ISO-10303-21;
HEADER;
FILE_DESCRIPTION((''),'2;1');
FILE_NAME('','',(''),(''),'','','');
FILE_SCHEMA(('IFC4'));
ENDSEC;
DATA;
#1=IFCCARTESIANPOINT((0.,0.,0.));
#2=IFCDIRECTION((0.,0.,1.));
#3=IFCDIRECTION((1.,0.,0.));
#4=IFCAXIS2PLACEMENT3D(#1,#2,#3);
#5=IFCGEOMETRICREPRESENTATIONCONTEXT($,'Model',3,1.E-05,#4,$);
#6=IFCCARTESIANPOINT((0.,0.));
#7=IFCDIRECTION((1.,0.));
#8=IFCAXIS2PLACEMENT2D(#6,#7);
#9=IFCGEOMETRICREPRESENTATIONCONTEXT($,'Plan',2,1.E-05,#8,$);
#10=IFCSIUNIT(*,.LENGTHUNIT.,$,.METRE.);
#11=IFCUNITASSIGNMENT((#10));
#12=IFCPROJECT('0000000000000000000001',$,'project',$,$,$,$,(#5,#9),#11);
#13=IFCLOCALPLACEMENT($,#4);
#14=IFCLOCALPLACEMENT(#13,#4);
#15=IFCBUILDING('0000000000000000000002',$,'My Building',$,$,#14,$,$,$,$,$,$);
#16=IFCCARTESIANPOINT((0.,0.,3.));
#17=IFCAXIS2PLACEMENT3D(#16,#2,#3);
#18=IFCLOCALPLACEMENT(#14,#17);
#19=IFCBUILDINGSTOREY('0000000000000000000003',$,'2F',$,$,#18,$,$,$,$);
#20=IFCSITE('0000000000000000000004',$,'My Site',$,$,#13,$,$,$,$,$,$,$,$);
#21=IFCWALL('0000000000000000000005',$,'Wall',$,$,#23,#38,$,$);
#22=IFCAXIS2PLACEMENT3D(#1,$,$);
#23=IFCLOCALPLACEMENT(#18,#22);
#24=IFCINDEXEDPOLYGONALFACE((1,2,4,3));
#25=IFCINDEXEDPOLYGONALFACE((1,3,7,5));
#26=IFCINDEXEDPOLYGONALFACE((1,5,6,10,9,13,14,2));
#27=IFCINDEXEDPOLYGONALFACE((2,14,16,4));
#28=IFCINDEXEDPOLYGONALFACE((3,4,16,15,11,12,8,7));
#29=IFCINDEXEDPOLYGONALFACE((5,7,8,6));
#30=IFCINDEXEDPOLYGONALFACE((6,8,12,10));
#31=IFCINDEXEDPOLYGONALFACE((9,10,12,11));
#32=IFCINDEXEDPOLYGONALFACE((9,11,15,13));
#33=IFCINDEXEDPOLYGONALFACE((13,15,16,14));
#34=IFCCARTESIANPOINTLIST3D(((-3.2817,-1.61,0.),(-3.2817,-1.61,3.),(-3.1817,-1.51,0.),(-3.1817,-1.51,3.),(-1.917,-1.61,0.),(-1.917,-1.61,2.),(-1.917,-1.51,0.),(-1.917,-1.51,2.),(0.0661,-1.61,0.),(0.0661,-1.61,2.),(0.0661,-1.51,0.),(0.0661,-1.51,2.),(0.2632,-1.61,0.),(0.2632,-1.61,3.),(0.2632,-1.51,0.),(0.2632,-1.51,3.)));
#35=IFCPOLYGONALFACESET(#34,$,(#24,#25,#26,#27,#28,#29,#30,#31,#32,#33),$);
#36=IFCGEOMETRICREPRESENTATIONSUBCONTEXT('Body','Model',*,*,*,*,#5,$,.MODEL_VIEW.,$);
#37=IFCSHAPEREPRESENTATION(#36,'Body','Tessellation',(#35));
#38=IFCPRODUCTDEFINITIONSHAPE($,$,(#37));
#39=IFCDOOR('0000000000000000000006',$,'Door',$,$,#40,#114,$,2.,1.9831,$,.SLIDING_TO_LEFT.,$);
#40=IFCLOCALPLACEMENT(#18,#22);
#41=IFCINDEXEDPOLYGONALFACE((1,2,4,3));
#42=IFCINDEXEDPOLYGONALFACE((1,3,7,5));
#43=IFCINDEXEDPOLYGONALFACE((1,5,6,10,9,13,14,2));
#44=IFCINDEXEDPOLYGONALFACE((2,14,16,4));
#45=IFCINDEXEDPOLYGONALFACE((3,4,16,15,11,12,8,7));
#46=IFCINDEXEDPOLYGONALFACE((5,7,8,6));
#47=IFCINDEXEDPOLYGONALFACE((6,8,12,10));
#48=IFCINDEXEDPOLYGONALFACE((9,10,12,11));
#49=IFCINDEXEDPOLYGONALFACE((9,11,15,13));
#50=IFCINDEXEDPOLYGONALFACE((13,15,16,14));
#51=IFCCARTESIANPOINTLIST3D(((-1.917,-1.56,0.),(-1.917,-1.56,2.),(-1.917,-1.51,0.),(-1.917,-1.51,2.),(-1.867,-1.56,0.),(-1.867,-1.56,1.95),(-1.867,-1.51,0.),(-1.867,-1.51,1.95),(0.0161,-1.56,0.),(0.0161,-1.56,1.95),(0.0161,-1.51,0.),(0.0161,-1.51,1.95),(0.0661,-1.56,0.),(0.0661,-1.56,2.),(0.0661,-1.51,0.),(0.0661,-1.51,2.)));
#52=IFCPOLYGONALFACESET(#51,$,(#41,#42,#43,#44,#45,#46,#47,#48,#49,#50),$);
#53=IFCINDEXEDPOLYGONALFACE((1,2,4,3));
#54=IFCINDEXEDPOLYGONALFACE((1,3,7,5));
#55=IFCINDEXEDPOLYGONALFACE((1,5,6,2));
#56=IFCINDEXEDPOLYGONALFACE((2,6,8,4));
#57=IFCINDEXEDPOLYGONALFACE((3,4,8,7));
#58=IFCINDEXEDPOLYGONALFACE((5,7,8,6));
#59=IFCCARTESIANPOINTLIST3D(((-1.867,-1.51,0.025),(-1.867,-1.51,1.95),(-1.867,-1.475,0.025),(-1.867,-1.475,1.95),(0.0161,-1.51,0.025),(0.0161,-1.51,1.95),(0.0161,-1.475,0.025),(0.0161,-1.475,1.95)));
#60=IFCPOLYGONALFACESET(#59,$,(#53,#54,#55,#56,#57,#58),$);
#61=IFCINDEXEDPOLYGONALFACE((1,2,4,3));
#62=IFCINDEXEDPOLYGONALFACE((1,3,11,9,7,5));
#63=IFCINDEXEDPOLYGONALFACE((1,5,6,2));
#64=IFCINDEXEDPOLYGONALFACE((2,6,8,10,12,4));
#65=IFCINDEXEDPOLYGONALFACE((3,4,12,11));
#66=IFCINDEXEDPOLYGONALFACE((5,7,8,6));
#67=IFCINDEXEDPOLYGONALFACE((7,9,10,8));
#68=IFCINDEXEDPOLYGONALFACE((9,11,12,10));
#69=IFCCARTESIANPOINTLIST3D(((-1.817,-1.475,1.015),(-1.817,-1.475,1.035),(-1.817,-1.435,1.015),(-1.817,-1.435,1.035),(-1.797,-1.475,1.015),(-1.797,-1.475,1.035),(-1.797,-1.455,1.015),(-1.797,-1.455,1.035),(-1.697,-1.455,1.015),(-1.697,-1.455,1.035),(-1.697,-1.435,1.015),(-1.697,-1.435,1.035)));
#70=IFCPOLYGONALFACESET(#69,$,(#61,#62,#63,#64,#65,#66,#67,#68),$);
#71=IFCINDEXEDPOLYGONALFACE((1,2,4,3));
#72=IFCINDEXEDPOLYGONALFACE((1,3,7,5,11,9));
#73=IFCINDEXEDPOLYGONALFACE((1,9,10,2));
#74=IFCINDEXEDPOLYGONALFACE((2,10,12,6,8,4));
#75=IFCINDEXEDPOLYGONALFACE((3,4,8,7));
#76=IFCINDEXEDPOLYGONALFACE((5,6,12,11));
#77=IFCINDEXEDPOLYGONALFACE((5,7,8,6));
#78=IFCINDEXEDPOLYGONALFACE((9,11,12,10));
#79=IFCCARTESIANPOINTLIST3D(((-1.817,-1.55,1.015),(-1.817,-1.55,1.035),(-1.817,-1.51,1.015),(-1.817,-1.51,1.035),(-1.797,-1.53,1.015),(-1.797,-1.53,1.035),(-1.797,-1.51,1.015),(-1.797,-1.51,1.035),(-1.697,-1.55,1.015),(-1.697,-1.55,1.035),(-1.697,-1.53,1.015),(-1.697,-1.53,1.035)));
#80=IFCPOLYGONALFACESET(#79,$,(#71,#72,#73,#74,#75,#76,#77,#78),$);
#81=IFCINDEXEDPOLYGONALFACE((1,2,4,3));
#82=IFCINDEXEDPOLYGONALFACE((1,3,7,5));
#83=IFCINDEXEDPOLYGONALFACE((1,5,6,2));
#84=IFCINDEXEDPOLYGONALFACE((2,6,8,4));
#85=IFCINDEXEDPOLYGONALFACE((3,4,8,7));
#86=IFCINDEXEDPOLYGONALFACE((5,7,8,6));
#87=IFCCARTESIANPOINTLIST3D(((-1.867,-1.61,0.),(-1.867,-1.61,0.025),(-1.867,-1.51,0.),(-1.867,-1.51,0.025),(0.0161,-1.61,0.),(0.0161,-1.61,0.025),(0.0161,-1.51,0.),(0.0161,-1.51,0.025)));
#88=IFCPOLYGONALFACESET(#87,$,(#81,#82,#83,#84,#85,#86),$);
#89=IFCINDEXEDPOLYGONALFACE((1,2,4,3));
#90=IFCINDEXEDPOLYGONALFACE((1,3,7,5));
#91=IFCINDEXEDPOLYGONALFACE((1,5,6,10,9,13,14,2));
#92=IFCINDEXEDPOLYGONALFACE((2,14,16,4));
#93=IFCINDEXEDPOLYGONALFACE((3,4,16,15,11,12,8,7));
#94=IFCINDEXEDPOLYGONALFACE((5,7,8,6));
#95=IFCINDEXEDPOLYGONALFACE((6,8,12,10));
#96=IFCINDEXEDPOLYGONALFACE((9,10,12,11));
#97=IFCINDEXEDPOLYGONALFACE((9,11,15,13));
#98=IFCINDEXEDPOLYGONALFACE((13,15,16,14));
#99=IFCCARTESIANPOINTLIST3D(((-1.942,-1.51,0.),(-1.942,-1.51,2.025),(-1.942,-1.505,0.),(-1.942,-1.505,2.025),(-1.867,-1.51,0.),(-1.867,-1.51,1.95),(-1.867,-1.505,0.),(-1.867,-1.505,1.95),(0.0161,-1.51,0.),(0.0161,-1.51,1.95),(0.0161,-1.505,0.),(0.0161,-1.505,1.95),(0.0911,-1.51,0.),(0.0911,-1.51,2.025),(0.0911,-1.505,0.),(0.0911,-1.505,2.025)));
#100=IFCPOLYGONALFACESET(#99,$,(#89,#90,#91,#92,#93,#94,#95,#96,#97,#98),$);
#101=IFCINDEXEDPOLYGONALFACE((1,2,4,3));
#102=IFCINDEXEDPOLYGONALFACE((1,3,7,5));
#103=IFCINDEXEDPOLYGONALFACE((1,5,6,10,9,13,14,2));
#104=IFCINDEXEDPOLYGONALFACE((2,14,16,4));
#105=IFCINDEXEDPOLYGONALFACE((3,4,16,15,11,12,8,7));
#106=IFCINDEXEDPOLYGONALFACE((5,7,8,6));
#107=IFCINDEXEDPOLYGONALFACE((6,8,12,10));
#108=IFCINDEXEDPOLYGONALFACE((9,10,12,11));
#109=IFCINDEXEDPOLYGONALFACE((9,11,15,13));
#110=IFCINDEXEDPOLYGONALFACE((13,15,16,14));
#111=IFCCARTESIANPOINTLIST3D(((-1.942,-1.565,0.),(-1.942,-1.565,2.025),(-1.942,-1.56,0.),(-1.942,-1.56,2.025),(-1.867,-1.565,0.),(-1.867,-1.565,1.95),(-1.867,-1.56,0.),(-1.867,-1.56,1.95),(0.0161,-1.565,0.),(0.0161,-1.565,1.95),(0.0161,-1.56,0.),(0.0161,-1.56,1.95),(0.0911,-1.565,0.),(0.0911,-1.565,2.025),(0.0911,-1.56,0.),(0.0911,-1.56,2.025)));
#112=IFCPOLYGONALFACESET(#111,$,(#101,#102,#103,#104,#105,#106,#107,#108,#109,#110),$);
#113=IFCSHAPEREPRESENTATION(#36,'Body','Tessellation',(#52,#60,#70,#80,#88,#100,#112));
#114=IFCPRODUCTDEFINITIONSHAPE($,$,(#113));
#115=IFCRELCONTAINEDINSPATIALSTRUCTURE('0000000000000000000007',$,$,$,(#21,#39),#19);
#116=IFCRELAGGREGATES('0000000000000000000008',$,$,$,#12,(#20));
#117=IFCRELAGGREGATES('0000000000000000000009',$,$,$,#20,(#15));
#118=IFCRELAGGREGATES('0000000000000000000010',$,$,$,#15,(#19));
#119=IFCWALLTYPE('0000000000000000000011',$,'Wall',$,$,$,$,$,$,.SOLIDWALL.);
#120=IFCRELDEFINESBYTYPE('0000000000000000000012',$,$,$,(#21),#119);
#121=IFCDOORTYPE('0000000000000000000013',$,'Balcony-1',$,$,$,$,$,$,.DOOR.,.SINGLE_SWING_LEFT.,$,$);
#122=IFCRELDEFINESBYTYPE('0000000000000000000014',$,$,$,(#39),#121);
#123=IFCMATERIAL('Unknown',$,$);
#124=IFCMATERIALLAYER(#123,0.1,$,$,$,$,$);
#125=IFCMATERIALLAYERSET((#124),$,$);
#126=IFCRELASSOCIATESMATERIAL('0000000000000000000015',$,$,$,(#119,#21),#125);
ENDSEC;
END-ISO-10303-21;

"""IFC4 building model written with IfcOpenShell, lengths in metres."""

from ifc_helpers import new_model, entity, si_unit, frame, origin_with_axes, origin_2d_with_axis, place, context, subcontext, project, spatial, line, indexed_curve, outline, extrude, shape, source, transform, mapped, material, layer, layer_set, layer_usage, type_object, type_shapes, element, fill, save


model = new_model("IFC4")

# Units and contexts
model_context = context("Model", 3, precision=1e-05, world=origin_with_axes())
plan_context = context("Plan", 2, precision=1e-05, world=origin_2d_with_axis())
body_context_1 = subcontext(model_context, "Body", "Model", "MODEL_VIEW")
body_context_2 = subcontext(plan_context, "Body", "Plan", "PLAN_VIEW")
ifc_project = project(units=[si_unit("LENGTHUNIT", "METRE")], contexts=[model_context, plan_context])

# Site, building, storey
site_placement = place(None, origin_with_axes())
site = spatial("IfcSite", under=ifc_project, at=site_placement, Name="My Site")
building_placement = place(site_placement, origin_with_axes())
building = spatial("IfcBuilding", under=site, at=building_placement, Name="My Building")
storey_placement = place(building_placement, frame((0.0, 0.0, 3.0), z_axis=(0.0, 0.0, 1.0), x_axis=(1.0, 0.0, 0.0)))
storey = spatial("IfcBuildingStorey", under=building, at=storey_placement, Name="2F")

# Shared definitions
ifc_material = material(Name="Unknown")

# Shared definitions
ifc_layer_1 = layer(ifc_material, 0.1)
ifc_layer_set_1 = layer_set([ifc_layer_1])
wall_type = type_object("IfcWallType", Name="Wall", PredefinedType="SOLIDWALL", material=ifc_layer_set_1)

# Wall, opening, door
ifc_layer_usage_1 = layer_usage(ifc_layer_set_1, "AXIS2", "POSITIVE", 0.0)
wall_1_placement = place(storey_placement, frame((-3.2817, -1.61, 0.0), z_axis=(0.0, 0.0, 1.0), x_axis=(1.0, 0.0, 0.0)))
wall_1 = element("IfcWall", 1, at=wall_1_placement, inside=storey, type_object=wall_type, material=ifc_layer_usage_1, Name="Wall", context=body_context_1, shape_type="SweptSolid", body=[
    extrude(outline(indexed_curve([(0.0, 0.0), (0.1, 0.1), (3.5448, 0.1), (3.5448, 0.0)], segments=[line(1, 2, 3, 4, 1)])), origin_with_axes(), (0.0, 0.0, 1.0), 3.0),
])
shared_shape_1 = source(origin_with_axes(), body_context_1, "Body", "SweptSolid", [
    extrude(outline(indexed_curve([(0.0, 0.0), (1.9831, 0.0), (1.9831, 2.0), (0.0, 2.0)], segments=[line(1, 2, 3, 4, 1)])), frame((0.0, -0.6, 0.0), z_axis=(0.0, -1.0, 0.0), x_axis=(1.0, 0.0, 0.0)), (0.0, 0.0, -1.0), 1.2),
])
opening_1_placement = place(wall_1_placement, frame((3.3477, 0.1, 0.0), z_axis=(0.0, 0.0, 1.0), x_axis=(-1.0, 0.0, 0.0)))
opening_1 = element("IfcOpeningElement", 2, at=opening_1_placement, cuts=wall_1, PredefinedType="OPENING", context=body_context_1, shape_type="MappedRepresentation", body=[
    mapped(shared_shape_1, transform((0.0, 0.0, 0.0), x_axis=(1.0, 0.0, 0.0), y_axis=(0.0, 1.0, 0.0), z_axis=(0.0, 0.0, 1.0), scale=1.0)),
])
door_type_1 = type_object("IfcDoorType", Name="Balcony-1", OperationType="SINGLE_SWING_LEFT", PredefinedType="DOOR")
shared_shape_2 = source(origin_with_axes(), body_context_1, "Body", "SweptSolid", [
    extrude(outline(indexed_curve([(0.0, 0.0), (0.0, 2.0), (1.9831, 2.0), (1.9831, 0.0), (1.9331, 0.0), (1.9331, 1.95), (0.05, 1.95), (0.05, 0.0)], segments=[line(1, 2, 3, 4, 5, 6, 7, 8, 1)])), frame((0.0, 0.0, 0.0), z_axis=(0.0, -1.0, 0.0), x_axis=(1.0, 0.0, 0.0)), (0.0, 0.0, -1.0), 0.05),
    extrude(outline(indexed_curve([(0.0, 0.0), (1.8831, 0.0), (1.8831, 0.035), (0.0, 0.035)], segments=[line(1, 2, 3, 4, 1)])), frame((0.05, -0.035, 0.025), z_axis=(0.0, 0.0, 1.0), x_axis=(1.0, 0.0, 0.0)), (0.0, 0.0, 1.0), 1.925),
    extrude(outline(indexed_curve([(0.0, 0.0), (0.0, -0.04), (-0.12, -0.04), (-0.12, -0.02), (-0.02, -0.02), (-0.02, 0.0)], segments=[line(1, 2, 3, 4, 5, 6, 1)])), frame((1.8831, -0.035, 1.015), z_axis=(0.0, 0.0, 1.0), x_axis=(1.0, 0.0, 0.0)), (0.0, 0.0, 1.0), 0.02),
    extrude(outline(indexed_curve([(0.0, 0.0), (0.0, 0.04), (-0.12, 0.04), (-0.12, 0.02), (-0.02, 0.02), (-0.02, 0.0)], segments=[line(1, 2, 3, 4, 5, 6, 1)])), frame((1.8831, 0.0, 1.015), z_axis=(0.0, 0.0, 1.0), x_axis=(1.0, 0.0, 0.0)), (0.0, 0.0, 1.0), 0.02),
    extrude(outline(indexed_curve([(0.0, 0.0), (1.8831, 0.0), (1.8831, 0.1), (0.0, 0.1)], segments=[line(1, 2, 3, 4, 1)])), frame((0.05, 0.0, 0.0), z_axis=(0.0, 0.0, 1.0), x_axis=(1.0, 0.0, 0.0)), (0.0, 0.0, 1.0), 0.025),
    extrude(outline(indexed_curve([(0.0, 0.0), (0.0, 2.025), (2.0331, 2.025), (2.0331, 0.0), (1.9581, 0.0), (1.9581, 1.95), (0.075, 1.95), (0.075, 0.0)], segments=[line(1, 2, 3, 4, 5, 6, 7, 8, 1)])), frame((-0.025, -0.005, 0.0), z_axis=(0.0, -1.0, 0.0), x_axis=(1.0, 0.0, 0.0)), (0.0, 0.0, -1.0), 0.005),
    extrude(outline(indexed_curve([(0.0, 0.0), (0.0, 2.025), (2.0331, 2.025), (2.0331, 0.0), (1.9581, 0.0), (1.9581, 1.95), (0.075, 1.95), (0.075, 0.0)], segments=[line(1, 2, 3, 4, 5, 6, 7, 8, 1)])), frame((-0.025, 0.05, 0.0), z_axis=(0.0, -1.0, 0.0), x_axis=(1.0, 0.0, 0.0)), (0.0, 0.0, -1.0), 0.005),
])
shared_shape_3 = source(origin_with_axes(), body_context_2, "Body", "Curve2D", [
    entity("IfcIndexedPolyCurve", entity("IfcCartesianPointList2D", [[0.0, 0.0], [0.05, 0.0], [0.05, 0.05], [0.0, 0.05]]), [entity("IfcLineIndex", [1, 2, 3, 4, 1])]),
    entity("IfcIndexedPolyCurve", entity("IfcCartesianPointList2D", [[1.9831, 0.0], [1.9331, 0.0], [1.9331, 0.05], [1.9831, 0.05]]), [entity("IfcLineIndex", [1, 2, 3, 4, 1])]),
    entity("IfcIndexedPolyCurve", entity("IfcCartesianPointList2D", [[-0.8915, -0.035], [0.9915, -0.035], [0.9915, 0.0], [-0.8915, 0.0]]), [entity("IfcLineIndex", [1, 2, 3, 4, 1])]),
])
type_shapes(door_type_1, [shared_shape_2, shared_shape_3])
door_1_placement = place(opening_1_placement, frame((0.0, 0.0, 0.0), z_axis=(0.0, 0.0, 1.0), x_axis=(1.0, 0.0, 0.0)))
door_1 = element("IfcDoor", 3, at=door_1_placement, inside=storey, type_object=door_type_1, Name="Door", OperationType="SLIDING_TO_LEFT", OverallHeight=2.0, OverallWidth=1.9831, shapes=[
    shape(body_context_1, "Body", "MappedRepresentation", [mapped(shared_shape_2, transform((0.0, 0.0, 0.0), x_axis=(1.0, 0.0, 0.0), y_axis=(0.0, 1.0, 0.0), z_axis=(0.0, 0.0, 1.0), scale=1.0))]),
    shape(body_context_2, "Body", "MappedRepresentation", [mapped(shared_shape_3, transform((0.0, 0.0, 0.0), x_axis=(1.0, 0.0, 0.0), y_axis=(0.0, 1.0, 0.0), z_axis=(0.0, 0.0, 1.0), scale=1.0))]),
])
fill(opening_1, door_1)

save(model, "model.ifc")
